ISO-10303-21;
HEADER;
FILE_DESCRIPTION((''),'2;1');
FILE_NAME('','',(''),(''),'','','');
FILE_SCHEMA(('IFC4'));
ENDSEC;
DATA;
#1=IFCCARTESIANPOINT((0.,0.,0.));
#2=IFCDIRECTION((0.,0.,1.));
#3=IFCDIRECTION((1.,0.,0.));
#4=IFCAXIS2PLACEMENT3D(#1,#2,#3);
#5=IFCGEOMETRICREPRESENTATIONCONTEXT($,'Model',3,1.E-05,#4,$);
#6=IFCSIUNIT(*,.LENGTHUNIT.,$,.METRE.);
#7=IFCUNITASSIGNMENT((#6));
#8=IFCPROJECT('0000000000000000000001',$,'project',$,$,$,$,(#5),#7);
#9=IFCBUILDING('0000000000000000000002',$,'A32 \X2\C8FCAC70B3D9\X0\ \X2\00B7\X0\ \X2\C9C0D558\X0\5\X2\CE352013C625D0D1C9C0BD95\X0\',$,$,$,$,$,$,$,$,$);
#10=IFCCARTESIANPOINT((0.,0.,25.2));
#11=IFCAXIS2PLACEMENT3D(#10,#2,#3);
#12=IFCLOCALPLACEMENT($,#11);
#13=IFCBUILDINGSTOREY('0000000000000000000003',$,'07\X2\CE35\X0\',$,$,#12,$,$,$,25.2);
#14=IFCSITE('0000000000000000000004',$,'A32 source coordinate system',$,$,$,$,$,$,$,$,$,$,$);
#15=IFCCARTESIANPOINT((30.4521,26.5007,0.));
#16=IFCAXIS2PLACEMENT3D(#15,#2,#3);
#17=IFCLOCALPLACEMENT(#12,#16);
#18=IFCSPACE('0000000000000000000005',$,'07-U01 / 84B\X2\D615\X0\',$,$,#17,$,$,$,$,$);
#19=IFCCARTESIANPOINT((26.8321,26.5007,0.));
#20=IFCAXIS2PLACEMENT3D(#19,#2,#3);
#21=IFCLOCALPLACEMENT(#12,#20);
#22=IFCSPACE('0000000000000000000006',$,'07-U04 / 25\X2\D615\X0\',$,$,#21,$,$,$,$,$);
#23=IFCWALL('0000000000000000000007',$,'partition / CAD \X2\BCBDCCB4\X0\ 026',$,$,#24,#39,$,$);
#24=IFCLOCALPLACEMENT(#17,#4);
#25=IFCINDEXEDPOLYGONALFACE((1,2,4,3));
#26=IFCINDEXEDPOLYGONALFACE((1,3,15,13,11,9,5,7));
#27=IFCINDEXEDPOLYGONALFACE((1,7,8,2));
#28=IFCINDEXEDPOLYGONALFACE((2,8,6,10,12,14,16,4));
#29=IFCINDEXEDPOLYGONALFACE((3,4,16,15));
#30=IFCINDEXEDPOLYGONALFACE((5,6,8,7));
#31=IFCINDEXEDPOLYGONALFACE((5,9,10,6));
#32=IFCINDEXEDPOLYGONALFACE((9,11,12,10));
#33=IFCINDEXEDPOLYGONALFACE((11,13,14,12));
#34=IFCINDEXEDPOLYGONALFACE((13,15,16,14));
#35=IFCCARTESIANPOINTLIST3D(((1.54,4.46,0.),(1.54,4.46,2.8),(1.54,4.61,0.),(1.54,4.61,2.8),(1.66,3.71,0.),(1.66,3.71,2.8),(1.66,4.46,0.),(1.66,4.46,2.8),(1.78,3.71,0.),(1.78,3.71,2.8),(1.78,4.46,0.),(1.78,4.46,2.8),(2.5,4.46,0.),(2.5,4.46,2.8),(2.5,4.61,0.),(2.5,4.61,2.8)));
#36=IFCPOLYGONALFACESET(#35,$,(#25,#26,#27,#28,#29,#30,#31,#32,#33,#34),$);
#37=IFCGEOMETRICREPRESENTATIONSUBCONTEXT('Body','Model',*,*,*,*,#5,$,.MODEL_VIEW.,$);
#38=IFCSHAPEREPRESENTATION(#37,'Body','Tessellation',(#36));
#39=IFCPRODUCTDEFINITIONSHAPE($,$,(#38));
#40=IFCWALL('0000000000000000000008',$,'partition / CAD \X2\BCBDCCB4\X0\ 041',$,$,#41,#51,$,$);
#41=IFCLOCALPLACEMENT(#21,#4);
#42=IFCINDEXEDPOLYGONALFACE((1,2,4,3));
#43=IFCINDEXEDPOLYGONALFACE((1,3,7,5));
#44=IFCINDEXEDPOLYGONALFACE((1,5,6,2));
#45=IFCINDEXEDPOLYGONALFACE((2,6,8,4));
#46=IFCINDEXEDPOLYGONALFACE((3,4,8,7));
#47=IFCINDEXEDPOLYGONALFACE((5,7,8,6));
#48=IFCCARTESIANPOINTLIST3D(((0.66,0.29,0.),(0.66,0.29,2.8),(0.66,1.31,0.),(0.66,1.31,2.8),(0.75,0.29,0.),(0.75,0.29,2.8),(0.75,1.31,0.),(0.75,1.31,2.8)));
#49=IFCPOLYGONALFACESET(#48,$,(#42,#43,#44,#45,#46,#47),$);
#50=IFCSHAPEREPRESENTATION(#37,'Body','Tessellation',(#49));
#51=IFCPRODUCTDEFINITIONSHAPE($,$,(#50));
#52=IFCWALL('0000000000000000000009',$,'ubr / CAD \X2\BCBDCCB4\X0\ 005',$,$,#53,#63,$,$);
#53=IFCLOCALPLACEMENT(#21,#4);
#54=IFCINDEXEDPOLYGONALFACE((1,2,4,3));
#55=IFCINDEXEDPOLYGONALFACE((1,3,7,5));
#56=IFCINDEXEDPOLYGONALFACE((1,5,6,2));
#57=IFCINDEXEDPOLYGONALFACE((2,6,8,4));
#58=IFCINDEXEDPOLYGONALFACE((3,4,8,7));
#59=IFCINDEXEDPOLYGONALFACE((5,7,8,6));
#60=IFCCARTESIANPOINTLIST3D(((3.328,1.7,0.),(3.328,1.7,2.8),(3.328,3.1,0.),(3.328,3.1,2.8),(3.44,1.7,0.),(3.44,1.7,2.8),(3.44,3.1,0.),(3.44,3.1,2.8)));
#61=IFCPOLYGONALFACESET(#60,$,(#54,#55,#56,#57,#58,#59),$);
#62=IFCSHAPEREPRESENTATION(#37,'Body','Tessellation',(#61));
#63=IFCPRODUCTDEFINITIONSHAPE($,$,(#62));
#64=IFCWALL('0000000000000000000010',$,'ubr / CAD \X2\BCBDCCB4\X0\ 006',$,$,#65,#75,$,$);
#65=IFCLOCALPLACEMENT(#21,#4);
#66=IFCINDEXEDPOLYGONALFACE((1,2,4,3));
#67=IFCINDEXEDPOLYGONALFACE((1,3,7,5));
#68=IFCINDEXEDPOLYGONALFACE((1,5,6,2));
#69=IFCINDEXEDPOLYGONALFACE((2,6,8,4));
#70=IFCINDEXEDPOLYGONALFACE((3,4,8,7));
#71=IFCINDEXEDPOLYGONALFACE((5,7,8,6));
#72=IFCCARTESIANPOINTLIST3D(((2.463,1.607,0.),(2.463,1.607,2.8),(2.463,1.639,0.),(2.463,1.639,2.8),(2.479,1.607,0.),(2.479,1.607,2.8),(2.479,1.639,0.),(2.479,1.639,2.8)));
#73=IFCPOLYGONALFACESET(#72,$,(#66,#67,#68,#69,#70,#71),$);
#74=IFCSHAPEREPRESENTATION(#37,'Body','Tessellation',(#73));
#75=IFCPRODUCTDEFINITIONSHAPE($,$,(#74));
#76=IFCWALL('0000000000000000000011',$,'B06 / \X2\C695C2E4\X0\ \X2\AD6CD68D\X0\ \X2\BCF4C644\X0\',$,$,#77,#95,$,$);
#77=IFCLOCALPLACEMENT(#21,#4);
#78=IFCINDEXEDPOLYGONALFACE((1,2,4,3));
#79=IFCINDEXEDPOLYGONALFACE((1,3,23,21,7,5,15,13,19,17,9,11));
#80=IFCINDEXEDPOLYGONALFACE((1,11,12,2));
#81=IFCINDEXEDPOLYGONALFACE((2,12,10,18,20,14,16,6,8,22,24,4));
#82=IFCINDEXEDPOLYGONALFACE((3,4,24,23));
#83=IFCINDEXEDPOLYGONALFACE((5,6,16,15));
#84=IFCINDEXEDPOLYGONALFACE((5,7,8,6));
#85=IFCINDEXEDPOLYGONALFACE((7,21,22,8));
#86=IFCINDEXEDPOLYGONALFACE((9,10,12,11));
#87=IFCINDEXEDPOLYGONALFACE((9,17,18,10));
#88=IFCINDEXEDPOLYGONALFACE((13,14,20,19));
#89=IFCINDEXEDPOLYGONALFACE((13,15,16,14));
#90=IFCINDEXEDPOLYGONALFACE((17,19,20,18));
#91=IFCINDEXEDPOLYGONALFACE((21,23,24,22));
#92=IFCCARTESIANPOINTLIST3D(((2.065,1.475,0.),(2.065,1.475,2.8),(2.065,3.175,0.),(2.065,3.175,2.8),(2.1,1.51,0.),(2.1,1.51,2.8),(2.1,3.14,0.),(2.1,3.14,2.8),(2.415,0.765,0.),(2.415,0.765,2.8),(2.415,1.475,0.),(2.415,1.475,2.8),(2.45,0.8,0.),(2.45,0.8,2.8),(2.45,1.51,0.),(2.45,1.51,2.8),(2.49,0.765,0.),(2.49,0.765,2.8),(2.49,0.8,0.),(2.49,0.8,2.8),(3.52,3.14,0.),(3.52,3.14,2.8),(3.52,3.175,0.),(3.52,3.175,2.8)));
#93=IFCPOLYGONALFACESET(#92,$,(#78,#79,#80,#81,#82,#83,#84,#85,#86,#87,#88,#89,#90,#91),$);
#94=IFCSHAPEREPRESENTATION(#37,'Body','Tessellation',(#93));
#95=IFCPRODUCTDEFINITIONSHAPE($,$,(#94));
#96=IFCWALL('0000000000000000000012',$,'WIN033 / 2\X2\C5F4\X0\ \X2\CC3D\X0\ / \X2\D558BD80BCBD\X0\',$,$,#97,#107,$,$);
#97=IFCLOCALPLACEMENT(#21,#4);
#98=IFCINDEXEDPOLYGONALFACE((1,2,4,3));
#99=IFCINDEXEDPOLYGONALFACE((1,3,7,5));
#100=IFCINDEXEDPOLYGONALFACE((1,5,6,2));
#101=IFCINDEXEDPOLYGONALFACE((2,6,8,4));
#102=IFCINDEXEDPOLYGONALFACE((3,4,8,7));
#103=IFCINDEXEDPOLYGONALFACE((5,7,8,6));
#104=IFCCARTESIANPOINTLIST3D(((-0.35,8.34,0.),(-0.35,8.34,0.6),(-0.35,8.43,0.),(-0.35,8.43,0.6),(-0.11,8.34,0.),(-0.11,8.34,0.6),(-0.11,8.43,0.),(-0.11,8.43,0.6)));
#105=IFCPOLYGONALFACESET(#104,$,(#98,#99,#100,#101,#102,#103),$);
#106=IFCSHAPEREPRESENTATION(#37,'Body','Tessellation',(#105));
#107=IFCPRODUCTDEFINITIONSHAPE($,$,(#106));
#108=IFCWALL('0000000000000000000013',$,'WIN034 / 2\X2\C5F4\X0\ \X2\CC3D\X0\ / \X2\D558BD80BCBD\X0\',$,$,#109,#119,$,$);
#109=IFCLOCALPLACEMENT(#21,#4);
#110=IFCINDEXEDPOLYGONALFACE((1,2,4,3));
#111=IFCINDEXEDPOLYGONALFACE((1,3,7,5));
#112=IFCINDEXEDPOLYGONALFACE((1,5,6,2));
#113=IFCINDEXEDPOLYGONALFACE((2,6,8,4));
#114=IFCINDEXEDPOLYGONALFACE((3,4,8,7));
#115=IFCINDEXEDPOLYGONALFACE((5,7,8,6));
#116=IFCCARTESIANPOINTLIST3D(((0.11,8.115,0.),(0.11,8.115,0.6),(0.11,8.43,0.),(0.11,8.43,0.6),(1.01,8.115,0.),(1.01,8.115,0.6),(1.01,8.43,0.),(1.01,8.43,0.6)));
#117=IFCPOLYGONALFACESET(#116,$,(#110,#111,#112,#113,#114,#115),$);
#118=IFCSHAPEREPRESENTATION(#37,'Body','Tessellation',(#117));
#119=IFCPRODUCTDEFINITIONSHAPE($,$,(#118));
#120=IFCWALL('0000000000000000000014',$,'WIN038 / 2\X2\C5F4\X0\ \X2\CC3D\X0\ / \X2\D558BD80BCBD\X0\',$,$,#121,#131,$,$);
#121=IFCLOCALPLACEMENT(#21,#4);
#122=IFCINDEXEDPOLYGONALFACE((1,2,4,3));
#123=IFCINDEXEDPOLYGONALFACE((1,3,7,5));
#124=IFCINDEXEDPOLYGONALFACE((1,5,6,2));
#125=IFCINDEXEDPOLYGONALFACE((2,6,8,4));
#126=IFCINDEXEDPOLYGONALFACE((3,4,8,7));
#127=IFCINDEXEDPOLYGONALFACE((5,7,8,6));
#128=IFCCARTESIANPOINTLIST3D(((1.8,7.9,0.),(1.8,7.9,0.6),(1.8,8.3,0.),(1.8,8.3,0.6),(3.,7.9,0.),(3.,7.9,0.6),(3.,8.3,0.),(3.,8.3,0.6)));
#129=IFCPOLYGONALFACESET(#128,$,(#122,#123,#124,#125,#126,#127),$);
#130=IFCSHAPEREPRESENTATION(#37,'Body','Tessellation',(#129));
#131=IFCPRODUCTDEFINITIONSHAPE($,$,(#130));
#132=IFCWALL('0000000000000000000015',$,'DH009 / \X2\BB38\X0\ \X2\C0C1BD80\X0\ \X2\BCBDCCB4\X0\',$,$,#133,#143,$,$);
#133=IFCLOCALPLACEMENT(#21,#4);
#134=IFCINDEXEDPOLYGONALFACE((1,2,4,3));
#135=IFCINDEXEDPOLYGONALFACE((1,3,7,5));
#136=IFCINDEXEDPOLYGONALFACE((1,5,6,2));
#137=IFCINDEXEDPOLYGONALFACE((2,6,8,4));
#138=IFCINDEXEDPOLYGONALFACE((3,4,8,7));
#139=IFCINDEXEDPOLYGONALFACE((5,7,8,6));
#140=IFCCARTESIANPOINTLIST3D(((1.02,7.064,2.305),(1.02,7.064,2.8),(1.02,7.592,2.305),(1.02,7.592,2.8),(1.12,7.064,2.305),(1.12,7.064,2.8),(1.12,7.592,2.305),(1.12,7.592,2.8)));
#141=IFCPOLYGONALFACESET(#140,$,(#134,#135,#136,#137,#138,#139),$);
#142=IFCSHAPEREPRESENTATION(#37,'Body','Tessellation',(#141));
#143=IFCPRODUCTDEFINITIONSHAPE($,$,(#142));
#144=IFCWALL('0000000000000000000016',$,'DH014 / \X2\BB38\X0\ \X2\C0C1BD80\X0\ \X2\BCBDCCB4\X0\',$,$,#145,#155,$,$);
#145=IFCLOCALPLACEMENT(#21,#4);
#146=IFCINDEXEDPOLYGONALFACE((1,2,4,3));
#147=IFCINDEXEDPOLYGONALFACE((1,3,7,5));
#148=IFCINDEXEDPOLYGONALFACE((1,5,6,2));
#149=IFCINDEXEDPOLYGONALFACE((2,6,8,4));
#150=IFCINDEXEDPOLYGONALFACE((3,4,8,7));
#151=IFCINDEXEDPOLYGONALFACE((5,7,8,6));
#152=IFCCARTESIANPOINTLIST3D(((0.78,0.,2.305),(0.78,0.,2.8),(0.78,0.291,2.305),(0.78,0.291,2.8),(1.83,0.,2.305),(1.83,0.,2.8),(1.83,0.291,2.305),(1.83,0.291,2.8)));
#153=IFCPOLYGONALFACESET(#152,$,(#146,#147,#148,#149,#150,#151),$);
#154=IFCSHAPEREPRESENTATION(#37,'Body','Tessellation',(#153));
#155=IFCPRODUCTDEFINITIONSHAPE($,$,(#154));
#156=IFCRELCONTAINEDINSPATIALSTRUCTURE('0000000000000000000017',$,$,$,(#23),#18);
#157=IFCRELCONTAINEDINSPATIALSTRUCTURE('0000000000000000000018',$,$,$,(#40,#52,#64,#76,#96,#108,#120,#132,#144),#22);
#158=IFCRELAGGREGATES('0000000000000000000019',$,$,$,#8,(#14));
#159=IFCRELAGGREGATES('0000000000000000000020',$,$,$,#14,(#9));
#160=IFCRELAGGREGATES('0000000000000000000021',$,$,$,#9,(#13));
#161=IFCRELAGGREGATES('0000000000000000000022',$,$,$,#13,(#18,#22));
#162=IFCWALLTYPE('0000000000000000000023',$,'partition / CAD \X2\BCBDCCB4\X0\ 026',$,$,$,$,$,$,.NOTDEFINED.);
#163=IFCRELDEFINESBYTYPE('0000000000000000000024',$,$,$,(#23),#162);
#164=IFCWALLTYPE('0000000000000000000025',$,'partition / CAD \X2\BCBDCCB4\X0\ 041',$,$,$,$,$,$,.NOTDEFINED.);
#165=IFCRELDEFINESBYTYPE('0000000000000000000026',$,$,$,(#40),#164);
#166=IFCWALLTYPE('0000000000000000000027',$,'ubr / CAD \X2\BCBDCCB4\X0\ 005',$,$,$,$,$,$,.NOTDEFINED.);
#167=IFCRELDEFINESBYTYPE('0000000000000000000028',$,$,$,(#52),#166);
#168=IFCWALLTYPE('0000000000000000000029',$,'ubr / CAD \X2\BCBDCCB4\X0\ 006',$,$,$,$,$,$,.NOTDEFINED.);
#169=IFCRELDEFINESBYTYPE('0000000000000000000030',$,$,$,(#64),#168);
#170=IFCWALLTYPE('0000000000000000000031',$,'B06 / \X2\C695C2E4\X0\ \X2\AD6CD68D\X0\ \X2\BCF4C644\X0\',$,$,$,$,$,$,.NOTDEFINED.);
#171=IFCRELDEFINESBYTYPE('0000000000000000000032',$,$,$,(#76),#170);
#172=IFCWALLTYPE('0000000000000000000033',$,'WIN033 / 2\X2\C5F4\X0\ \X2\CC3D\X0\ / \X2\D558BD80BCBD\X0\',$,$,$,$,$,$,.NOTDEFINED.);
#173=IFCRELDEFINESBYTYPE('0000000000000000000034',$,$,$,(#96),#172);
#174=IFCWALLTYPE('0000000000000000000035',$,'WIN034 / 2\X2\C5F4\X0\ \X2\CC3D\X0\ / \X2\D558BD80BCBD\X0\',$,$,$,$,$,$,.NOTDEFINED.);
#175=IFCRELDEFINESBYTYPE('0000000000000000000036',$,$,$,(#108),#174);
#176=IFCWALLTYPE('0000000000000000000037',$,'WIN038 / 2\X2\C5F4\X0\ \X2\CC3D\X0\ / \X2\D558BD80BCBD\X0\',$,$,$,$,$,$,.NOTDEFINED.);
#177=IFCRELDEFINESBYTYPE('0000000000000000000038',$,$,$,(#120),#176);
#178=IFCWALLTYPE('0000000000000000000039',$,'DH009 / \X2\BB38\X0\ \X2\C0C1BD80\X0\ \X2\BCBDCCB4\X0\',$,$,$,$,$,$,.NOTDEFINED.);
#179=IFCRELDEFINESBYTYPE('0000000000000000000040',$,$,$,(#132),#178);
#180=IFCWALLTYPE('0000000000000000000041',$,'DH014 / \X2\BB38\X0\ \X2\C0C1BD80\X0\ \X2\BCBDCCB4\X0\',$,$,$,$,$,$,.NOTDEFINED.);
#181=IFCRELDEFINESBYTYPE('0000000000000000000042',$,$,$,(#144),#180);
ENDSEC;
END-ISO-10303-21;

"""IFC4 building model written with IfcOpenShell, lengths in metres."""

from ifc_helpers import new_model, si_unit, frame, origin, origin_with_axes, place, context, subcontext, project, spatial, polyline, outline, extrude, source, transform, mapped, type_object, type_shapes, element, save


model = new_model("IFC4")

# Units and contexts
model_context = context("Model", 3, precision=1e-05, world=origin_with_axes())
body_context = subcontext(model_context, "Body", "Model", "MODEL_VIEW")
ifc_project = project(units=[si_unit("LENGTHUNIT", "METRE")], contexts=[model_context])

# Site, building, storey, space
site = spatial("IfcSite", under=ifc_project, Name="A32 source coordinate system")
building = spatial("IfcBuilding", under=site, Name="A32 주거동 · 지하5층–옥탑지붕")
storey_placement = place(None, frame((0.0, 0.0, 25.2), z_axis=(0.0, 0.0, 1.0), x_axis=(1.0, 0.0, 0.0)))
storey = spatial("IfcBuildingStorey", under=building, at=storey_placement, Name="07층", Elevation=25.2)
space_1_placement = place(storey_placement, frame((30.4521, 26.5007, 0.0), z_axis=(0.0, 0.0, 1.0), x_axis=(1.0, 0.0, 0.0)))
space_1 = spatial("IfcSpace", under=storey, at=space_1_placement, Name="07-U01 / 84B형")

# Wall
wall_type_1 = type_object("IfcWallType", Name="partition / CAD 벽체 026", PredefinedType="NOTDEFINED")
shared_shape_1 = source(origin(), body_context, "Body", "SweptSolid", [
    extrude(outline(polyline([(1.54, 4.46), (1.54, 4.61), (2.5, 4.61), (2.5, 4.46), (1.78, 4.46), (1.78, 3.71), (1.66, 3.71), (1.66, 4.46), (1.54, 4.46)])), origin(), (0.0, 0.0, 1.0), 2.8),
])
type_shapes(wall_type_1, [shared_shape_1])
wall_1_placement = place(space_1_placement, origin_with_axes())
element("IfcWall", 1, at=wall_1_placement, inside=space_1, type_object=wall_type_1, Name="partition / CAD 벽체 026", context=body_context, shape_type="MappedRepresentation", body=[
    mapped(shared_shape_1, transform((0.0, 0.0, 0.0), scale=1.0)),
])

# Shared definitions
space_2_placement = place(storey_placement, frame((26.8321, 26.5007, 0.0), z_axis=(0.0, 0.0, 1.0), x_axis=(1.0, 0.0, 0.0)))
space_2 = spatial("IfcSpace", under=storey, at=space_2_placement, Name="07-U04 / 25형")

# Walls
wall_type_2 = type_object("IfcWallType", Name="partition / CAD 벽체 041", PredefinedType="NOTDEFINED")
shared_shape_2 = source(origin(), body_context, "Body", "SweptSolid", [
    extrude(outline(polyline([(0.75, 1.31), (0.75, 0.29), (0.66, 0.29), (0.66, 1.31), (0.75, 1.31)])), origin(), (0.0, 0.0, 1.0), 2.8),
])
type_shapes(wall_type_2, [shared_shape_2])
wall_2_placement = place(space_2_placement, origin_with_axes())
element("IfcWall", 2, at=wall_2_placement, inside=space_2, type_object=wall_type_2, Name="partition / CAD 벽체 041", context=body_context, shape_type="MappedRepresentation", body=[
    mapped(shared_shape_2, transform((0.0, 0.0, 0.0), scale=1.0)),
])
wall_type_3 = type_object("IfcWallType", Name="ubr / CAD 벽체 005", PredefinedType="NOTDEFINED")
shared_shape_3 = source(origin(), body_context, "Body", "SweptSolid", [
    extrude(outline(polyline([(3.44, 3.1), (3.44, 1.7), (3.328, 1.7), (3.328, 3.1), (3.44, 3.1)])), origin(), (0.0, 0.0, 1.0), 2.8),
])
type_shapes(wall_type_3, [shared_shape_3])
wall_3_placement = place(space_2_placement, origin_with_axes())
element("IfcWall", 3, at=wall_3_placement, inside=space_2, type_object=wall_type_3, Name="ubr / CAD 벽체 005", context=body_context, shape_type="MappedRepresentation", body=[
    mapped(shared_shape_3, transform((0.0, 0.0, 0.0), scale=1.0)),
])
wall_type_4 = type_object("IfcWallType", Name="ubr / CAD 벽체 006", PredefinedType="NOTDEFINED")
shared_shape_4 = source(origin(), body_context, "Body", "SweptSolid", [
    extrude(outline(polyline([(2.463, 1.639), (2.479, 1.639), (2.479, 1.607), (2.463, 1.607), (2.463, 1.639)])), origin(), (0.0, 0.0, 1.0), 2.8),
])
type_shapes(wall_type_4, [shared_shape_4])
wall_4_placement = place(space_2_placement, origin_with_axes())
element("IfcWall", 4, at=wall_4_placement, inside=space_2, type_object=wall_type_4, Name="ubr / CAD 벽체 006", context=body_context, shape_type="MappedRepresentation", body=[
    mapped(shared_shape_4, transform((0.0, 0.0, 0.0), scale=1.0)),
])
wall_type_5 = type_object("IfcWallType", Name="B06 / 욕실 구획 보완", PredefinedType="NOTDEFINED")
shared_shape_5 = source(origin(), body_context, "Body", "SweptSolid", [
    extrude(outline(polyline([(3.52, 3.14), (2.1, 3.14), (2.1, 1.51), (2.45, 1.51), (2.45, 0.8), (2.49, 0.8), (2.49, 0.765), (2.415, 0.765), (2.415, 1.475), (2.065, 1.475), (2.065, 3.175), (3.52, 3.175), (3.52, 3.14)])), origin(), (0.0, 0.0, 1.0), 2.8),
])
type_shapes(wall_type_5, [shared_shape_5])
wall_5_placement = place(space_2_placement, origin_with_axes())
element("IfcWall", 5, at=wall_5_placement, inside=space_2, type_object=wall_type_5, Name="B06 / 욕실 구획 보완", context=body_context, shape_type="MappedRepresentation", body=[
    mapped(shared_shape_5, transform((0.0, 0.0, 0.0), scale=1.0)),
])
wall_type_6 = type_object("IfcWallType", Name="WIN033 / 2열 창 / 하부벽", PredefinedType="NOTDEFINED")
shared_shape_6 = source(origin(), body_context, "Body", "SweptSolid", [
    extrude(outline(polyline([(-0.11, 8.43), (-0.11, 8.34), (-0.35, 8.34), (-0.35, 8.43), (-0.11, 8.43)])), origin(), (0.0, 0.0, 1.0), 0.6),
])
type_shapes(wall_type_6, [shared_shape_6])
wall_6_placement = place(space_2_placement, origin_with_axes())
element("IfcWall", 6, at=wall_6_placement, inside=space_2, type_object=wall_type_6, Name="WIN033 / 2열 창 / 하부벽", context=body_context, shape_type="MappedRepresentation", body=[
    mapped(shared_shape_6, transform((0.0, 0.0, 0.0), scale=1.0)),
])
wall_type_7 = type_object("IfcWallType", Name="WIN034 / 2열 창 / 하부벽", PredefinedType="NOTDEFINED")
shared_shape_7 = source(origin(), body_context, "Body", "SweptSolid", [
    extrude(outline(polyline([(0.11, 8.115), (0.11, 8.43), (1.01, 8.43), (1.01, 8.115), (0.11, 8.115)])), origin(), (0.0, 0.0, 1.0), 0.6),
])
type_shapes(wall_type_7, [shared_shape_7])
wall_7_placement = place(space_2_placement, origin_with_axes())
element("IfcWall", 7, at=wall_7_placement, inside=space_2, type_object=wall_type_7, Name="WIN034 / 2열 창 / 하부벽", context=body_context, shape_type="MappedRepresentation", body=[
    mapped(shared_shape_7, transform((0.0, 0.0, 0.0), scale=1.0)),
])
wall_type_8 = type_object("IfcWallType", Name="WIN038 / 2열 창 / 하부벽", PredefinedType="NOTDEFINED")
shared_shape_8 = source(origin(), body_context, "Body", "SweptSolid", [
    extrude(outline(polyline([(1.8, 7.9), (1.8, 8.3), (3.0, 8.3), (3.0, 7.9), (1.8, 7.9)])), origin(), (0.0, 0.0, 1.0), 0.6),
])
type_shapes(wall_type_8, [shared_shape_8])
wall_8_placement = place(space_2_placement, origin_with_axes())
element("IfcWall", 8, at=wall_8_placement, inside=space_2, type_object=wall_type_8, Name="WIN038 / 2열 창 / 하부벽", context=body_context, shape_type="MappedRepresentation", body=[
    mapped(shared_shape_8, transform((0.0, 0.0, 0.0), scale=1.0)),
])
wall_type_9 = type_object("IfcWallType", Name="DH009 / 문 상부 벽체", PredefinedType="NOTDEFINED")
shared_shape_9 = source(origin(), body_context, "Body", "SweptSolid", [
    extrude(outline(polyline([(1.02, 7.064), (1.02, 7.592), (1.12, 7.592), (1.12, 7.064), (1.02, 7.064)])), frame((0.0, 0.0, 2.305)), (0.0, 0.0, 1.0), 0.495),
])
type_shapes(wall_type_9, [shared_shape_9])
wall_9_placement = place(space_2_placement, origin_with_axes())
element("IfcWall", 9, at=wall_9_placement, inside=space_2, type_object=wall_type_9, Name="DH009 / 문 상부 벽체", context=body_context, shape_type="MappedRepresentation", body=[
    mapped(shared_shape_9, transform((0.0, 0.0, 0.0), scale=1.0)),
])
wall_type_10 = type_object("IfcWallType", Name="DH014 / 문 상부 벽체", PredefinedType="NOTDEFINED")
shared_shape_10 = source(origin(), body_context, "Body", "SweptSolid", [
    extrude(outline(polyline([(0.78, 0.291), (1.83, 0.291), (1.83, 0.0), (0.78, 0.0), (0.78, 0.291)])), frame((0.0, 0.0, 2.305)), (0.0, 0.0, 1.0), 0.495),
])
type_shapes(wall_type_10, [shared_shape_10])
wall_10_placement = place(space_2_placement, origin_with_axes())
element("IfcWall", 10, at=wall_10_placement, inside=space_2, type_object=wall_type_10, Name="DH014 / 문 상부 벽체", context=body_context, shape_type="MappedRepresentation", body=[
    mapped(shared_shape_10, transform((0.0, 0.0, 0.0), scale=1.0)),
])

save(model, "model.ifc")
